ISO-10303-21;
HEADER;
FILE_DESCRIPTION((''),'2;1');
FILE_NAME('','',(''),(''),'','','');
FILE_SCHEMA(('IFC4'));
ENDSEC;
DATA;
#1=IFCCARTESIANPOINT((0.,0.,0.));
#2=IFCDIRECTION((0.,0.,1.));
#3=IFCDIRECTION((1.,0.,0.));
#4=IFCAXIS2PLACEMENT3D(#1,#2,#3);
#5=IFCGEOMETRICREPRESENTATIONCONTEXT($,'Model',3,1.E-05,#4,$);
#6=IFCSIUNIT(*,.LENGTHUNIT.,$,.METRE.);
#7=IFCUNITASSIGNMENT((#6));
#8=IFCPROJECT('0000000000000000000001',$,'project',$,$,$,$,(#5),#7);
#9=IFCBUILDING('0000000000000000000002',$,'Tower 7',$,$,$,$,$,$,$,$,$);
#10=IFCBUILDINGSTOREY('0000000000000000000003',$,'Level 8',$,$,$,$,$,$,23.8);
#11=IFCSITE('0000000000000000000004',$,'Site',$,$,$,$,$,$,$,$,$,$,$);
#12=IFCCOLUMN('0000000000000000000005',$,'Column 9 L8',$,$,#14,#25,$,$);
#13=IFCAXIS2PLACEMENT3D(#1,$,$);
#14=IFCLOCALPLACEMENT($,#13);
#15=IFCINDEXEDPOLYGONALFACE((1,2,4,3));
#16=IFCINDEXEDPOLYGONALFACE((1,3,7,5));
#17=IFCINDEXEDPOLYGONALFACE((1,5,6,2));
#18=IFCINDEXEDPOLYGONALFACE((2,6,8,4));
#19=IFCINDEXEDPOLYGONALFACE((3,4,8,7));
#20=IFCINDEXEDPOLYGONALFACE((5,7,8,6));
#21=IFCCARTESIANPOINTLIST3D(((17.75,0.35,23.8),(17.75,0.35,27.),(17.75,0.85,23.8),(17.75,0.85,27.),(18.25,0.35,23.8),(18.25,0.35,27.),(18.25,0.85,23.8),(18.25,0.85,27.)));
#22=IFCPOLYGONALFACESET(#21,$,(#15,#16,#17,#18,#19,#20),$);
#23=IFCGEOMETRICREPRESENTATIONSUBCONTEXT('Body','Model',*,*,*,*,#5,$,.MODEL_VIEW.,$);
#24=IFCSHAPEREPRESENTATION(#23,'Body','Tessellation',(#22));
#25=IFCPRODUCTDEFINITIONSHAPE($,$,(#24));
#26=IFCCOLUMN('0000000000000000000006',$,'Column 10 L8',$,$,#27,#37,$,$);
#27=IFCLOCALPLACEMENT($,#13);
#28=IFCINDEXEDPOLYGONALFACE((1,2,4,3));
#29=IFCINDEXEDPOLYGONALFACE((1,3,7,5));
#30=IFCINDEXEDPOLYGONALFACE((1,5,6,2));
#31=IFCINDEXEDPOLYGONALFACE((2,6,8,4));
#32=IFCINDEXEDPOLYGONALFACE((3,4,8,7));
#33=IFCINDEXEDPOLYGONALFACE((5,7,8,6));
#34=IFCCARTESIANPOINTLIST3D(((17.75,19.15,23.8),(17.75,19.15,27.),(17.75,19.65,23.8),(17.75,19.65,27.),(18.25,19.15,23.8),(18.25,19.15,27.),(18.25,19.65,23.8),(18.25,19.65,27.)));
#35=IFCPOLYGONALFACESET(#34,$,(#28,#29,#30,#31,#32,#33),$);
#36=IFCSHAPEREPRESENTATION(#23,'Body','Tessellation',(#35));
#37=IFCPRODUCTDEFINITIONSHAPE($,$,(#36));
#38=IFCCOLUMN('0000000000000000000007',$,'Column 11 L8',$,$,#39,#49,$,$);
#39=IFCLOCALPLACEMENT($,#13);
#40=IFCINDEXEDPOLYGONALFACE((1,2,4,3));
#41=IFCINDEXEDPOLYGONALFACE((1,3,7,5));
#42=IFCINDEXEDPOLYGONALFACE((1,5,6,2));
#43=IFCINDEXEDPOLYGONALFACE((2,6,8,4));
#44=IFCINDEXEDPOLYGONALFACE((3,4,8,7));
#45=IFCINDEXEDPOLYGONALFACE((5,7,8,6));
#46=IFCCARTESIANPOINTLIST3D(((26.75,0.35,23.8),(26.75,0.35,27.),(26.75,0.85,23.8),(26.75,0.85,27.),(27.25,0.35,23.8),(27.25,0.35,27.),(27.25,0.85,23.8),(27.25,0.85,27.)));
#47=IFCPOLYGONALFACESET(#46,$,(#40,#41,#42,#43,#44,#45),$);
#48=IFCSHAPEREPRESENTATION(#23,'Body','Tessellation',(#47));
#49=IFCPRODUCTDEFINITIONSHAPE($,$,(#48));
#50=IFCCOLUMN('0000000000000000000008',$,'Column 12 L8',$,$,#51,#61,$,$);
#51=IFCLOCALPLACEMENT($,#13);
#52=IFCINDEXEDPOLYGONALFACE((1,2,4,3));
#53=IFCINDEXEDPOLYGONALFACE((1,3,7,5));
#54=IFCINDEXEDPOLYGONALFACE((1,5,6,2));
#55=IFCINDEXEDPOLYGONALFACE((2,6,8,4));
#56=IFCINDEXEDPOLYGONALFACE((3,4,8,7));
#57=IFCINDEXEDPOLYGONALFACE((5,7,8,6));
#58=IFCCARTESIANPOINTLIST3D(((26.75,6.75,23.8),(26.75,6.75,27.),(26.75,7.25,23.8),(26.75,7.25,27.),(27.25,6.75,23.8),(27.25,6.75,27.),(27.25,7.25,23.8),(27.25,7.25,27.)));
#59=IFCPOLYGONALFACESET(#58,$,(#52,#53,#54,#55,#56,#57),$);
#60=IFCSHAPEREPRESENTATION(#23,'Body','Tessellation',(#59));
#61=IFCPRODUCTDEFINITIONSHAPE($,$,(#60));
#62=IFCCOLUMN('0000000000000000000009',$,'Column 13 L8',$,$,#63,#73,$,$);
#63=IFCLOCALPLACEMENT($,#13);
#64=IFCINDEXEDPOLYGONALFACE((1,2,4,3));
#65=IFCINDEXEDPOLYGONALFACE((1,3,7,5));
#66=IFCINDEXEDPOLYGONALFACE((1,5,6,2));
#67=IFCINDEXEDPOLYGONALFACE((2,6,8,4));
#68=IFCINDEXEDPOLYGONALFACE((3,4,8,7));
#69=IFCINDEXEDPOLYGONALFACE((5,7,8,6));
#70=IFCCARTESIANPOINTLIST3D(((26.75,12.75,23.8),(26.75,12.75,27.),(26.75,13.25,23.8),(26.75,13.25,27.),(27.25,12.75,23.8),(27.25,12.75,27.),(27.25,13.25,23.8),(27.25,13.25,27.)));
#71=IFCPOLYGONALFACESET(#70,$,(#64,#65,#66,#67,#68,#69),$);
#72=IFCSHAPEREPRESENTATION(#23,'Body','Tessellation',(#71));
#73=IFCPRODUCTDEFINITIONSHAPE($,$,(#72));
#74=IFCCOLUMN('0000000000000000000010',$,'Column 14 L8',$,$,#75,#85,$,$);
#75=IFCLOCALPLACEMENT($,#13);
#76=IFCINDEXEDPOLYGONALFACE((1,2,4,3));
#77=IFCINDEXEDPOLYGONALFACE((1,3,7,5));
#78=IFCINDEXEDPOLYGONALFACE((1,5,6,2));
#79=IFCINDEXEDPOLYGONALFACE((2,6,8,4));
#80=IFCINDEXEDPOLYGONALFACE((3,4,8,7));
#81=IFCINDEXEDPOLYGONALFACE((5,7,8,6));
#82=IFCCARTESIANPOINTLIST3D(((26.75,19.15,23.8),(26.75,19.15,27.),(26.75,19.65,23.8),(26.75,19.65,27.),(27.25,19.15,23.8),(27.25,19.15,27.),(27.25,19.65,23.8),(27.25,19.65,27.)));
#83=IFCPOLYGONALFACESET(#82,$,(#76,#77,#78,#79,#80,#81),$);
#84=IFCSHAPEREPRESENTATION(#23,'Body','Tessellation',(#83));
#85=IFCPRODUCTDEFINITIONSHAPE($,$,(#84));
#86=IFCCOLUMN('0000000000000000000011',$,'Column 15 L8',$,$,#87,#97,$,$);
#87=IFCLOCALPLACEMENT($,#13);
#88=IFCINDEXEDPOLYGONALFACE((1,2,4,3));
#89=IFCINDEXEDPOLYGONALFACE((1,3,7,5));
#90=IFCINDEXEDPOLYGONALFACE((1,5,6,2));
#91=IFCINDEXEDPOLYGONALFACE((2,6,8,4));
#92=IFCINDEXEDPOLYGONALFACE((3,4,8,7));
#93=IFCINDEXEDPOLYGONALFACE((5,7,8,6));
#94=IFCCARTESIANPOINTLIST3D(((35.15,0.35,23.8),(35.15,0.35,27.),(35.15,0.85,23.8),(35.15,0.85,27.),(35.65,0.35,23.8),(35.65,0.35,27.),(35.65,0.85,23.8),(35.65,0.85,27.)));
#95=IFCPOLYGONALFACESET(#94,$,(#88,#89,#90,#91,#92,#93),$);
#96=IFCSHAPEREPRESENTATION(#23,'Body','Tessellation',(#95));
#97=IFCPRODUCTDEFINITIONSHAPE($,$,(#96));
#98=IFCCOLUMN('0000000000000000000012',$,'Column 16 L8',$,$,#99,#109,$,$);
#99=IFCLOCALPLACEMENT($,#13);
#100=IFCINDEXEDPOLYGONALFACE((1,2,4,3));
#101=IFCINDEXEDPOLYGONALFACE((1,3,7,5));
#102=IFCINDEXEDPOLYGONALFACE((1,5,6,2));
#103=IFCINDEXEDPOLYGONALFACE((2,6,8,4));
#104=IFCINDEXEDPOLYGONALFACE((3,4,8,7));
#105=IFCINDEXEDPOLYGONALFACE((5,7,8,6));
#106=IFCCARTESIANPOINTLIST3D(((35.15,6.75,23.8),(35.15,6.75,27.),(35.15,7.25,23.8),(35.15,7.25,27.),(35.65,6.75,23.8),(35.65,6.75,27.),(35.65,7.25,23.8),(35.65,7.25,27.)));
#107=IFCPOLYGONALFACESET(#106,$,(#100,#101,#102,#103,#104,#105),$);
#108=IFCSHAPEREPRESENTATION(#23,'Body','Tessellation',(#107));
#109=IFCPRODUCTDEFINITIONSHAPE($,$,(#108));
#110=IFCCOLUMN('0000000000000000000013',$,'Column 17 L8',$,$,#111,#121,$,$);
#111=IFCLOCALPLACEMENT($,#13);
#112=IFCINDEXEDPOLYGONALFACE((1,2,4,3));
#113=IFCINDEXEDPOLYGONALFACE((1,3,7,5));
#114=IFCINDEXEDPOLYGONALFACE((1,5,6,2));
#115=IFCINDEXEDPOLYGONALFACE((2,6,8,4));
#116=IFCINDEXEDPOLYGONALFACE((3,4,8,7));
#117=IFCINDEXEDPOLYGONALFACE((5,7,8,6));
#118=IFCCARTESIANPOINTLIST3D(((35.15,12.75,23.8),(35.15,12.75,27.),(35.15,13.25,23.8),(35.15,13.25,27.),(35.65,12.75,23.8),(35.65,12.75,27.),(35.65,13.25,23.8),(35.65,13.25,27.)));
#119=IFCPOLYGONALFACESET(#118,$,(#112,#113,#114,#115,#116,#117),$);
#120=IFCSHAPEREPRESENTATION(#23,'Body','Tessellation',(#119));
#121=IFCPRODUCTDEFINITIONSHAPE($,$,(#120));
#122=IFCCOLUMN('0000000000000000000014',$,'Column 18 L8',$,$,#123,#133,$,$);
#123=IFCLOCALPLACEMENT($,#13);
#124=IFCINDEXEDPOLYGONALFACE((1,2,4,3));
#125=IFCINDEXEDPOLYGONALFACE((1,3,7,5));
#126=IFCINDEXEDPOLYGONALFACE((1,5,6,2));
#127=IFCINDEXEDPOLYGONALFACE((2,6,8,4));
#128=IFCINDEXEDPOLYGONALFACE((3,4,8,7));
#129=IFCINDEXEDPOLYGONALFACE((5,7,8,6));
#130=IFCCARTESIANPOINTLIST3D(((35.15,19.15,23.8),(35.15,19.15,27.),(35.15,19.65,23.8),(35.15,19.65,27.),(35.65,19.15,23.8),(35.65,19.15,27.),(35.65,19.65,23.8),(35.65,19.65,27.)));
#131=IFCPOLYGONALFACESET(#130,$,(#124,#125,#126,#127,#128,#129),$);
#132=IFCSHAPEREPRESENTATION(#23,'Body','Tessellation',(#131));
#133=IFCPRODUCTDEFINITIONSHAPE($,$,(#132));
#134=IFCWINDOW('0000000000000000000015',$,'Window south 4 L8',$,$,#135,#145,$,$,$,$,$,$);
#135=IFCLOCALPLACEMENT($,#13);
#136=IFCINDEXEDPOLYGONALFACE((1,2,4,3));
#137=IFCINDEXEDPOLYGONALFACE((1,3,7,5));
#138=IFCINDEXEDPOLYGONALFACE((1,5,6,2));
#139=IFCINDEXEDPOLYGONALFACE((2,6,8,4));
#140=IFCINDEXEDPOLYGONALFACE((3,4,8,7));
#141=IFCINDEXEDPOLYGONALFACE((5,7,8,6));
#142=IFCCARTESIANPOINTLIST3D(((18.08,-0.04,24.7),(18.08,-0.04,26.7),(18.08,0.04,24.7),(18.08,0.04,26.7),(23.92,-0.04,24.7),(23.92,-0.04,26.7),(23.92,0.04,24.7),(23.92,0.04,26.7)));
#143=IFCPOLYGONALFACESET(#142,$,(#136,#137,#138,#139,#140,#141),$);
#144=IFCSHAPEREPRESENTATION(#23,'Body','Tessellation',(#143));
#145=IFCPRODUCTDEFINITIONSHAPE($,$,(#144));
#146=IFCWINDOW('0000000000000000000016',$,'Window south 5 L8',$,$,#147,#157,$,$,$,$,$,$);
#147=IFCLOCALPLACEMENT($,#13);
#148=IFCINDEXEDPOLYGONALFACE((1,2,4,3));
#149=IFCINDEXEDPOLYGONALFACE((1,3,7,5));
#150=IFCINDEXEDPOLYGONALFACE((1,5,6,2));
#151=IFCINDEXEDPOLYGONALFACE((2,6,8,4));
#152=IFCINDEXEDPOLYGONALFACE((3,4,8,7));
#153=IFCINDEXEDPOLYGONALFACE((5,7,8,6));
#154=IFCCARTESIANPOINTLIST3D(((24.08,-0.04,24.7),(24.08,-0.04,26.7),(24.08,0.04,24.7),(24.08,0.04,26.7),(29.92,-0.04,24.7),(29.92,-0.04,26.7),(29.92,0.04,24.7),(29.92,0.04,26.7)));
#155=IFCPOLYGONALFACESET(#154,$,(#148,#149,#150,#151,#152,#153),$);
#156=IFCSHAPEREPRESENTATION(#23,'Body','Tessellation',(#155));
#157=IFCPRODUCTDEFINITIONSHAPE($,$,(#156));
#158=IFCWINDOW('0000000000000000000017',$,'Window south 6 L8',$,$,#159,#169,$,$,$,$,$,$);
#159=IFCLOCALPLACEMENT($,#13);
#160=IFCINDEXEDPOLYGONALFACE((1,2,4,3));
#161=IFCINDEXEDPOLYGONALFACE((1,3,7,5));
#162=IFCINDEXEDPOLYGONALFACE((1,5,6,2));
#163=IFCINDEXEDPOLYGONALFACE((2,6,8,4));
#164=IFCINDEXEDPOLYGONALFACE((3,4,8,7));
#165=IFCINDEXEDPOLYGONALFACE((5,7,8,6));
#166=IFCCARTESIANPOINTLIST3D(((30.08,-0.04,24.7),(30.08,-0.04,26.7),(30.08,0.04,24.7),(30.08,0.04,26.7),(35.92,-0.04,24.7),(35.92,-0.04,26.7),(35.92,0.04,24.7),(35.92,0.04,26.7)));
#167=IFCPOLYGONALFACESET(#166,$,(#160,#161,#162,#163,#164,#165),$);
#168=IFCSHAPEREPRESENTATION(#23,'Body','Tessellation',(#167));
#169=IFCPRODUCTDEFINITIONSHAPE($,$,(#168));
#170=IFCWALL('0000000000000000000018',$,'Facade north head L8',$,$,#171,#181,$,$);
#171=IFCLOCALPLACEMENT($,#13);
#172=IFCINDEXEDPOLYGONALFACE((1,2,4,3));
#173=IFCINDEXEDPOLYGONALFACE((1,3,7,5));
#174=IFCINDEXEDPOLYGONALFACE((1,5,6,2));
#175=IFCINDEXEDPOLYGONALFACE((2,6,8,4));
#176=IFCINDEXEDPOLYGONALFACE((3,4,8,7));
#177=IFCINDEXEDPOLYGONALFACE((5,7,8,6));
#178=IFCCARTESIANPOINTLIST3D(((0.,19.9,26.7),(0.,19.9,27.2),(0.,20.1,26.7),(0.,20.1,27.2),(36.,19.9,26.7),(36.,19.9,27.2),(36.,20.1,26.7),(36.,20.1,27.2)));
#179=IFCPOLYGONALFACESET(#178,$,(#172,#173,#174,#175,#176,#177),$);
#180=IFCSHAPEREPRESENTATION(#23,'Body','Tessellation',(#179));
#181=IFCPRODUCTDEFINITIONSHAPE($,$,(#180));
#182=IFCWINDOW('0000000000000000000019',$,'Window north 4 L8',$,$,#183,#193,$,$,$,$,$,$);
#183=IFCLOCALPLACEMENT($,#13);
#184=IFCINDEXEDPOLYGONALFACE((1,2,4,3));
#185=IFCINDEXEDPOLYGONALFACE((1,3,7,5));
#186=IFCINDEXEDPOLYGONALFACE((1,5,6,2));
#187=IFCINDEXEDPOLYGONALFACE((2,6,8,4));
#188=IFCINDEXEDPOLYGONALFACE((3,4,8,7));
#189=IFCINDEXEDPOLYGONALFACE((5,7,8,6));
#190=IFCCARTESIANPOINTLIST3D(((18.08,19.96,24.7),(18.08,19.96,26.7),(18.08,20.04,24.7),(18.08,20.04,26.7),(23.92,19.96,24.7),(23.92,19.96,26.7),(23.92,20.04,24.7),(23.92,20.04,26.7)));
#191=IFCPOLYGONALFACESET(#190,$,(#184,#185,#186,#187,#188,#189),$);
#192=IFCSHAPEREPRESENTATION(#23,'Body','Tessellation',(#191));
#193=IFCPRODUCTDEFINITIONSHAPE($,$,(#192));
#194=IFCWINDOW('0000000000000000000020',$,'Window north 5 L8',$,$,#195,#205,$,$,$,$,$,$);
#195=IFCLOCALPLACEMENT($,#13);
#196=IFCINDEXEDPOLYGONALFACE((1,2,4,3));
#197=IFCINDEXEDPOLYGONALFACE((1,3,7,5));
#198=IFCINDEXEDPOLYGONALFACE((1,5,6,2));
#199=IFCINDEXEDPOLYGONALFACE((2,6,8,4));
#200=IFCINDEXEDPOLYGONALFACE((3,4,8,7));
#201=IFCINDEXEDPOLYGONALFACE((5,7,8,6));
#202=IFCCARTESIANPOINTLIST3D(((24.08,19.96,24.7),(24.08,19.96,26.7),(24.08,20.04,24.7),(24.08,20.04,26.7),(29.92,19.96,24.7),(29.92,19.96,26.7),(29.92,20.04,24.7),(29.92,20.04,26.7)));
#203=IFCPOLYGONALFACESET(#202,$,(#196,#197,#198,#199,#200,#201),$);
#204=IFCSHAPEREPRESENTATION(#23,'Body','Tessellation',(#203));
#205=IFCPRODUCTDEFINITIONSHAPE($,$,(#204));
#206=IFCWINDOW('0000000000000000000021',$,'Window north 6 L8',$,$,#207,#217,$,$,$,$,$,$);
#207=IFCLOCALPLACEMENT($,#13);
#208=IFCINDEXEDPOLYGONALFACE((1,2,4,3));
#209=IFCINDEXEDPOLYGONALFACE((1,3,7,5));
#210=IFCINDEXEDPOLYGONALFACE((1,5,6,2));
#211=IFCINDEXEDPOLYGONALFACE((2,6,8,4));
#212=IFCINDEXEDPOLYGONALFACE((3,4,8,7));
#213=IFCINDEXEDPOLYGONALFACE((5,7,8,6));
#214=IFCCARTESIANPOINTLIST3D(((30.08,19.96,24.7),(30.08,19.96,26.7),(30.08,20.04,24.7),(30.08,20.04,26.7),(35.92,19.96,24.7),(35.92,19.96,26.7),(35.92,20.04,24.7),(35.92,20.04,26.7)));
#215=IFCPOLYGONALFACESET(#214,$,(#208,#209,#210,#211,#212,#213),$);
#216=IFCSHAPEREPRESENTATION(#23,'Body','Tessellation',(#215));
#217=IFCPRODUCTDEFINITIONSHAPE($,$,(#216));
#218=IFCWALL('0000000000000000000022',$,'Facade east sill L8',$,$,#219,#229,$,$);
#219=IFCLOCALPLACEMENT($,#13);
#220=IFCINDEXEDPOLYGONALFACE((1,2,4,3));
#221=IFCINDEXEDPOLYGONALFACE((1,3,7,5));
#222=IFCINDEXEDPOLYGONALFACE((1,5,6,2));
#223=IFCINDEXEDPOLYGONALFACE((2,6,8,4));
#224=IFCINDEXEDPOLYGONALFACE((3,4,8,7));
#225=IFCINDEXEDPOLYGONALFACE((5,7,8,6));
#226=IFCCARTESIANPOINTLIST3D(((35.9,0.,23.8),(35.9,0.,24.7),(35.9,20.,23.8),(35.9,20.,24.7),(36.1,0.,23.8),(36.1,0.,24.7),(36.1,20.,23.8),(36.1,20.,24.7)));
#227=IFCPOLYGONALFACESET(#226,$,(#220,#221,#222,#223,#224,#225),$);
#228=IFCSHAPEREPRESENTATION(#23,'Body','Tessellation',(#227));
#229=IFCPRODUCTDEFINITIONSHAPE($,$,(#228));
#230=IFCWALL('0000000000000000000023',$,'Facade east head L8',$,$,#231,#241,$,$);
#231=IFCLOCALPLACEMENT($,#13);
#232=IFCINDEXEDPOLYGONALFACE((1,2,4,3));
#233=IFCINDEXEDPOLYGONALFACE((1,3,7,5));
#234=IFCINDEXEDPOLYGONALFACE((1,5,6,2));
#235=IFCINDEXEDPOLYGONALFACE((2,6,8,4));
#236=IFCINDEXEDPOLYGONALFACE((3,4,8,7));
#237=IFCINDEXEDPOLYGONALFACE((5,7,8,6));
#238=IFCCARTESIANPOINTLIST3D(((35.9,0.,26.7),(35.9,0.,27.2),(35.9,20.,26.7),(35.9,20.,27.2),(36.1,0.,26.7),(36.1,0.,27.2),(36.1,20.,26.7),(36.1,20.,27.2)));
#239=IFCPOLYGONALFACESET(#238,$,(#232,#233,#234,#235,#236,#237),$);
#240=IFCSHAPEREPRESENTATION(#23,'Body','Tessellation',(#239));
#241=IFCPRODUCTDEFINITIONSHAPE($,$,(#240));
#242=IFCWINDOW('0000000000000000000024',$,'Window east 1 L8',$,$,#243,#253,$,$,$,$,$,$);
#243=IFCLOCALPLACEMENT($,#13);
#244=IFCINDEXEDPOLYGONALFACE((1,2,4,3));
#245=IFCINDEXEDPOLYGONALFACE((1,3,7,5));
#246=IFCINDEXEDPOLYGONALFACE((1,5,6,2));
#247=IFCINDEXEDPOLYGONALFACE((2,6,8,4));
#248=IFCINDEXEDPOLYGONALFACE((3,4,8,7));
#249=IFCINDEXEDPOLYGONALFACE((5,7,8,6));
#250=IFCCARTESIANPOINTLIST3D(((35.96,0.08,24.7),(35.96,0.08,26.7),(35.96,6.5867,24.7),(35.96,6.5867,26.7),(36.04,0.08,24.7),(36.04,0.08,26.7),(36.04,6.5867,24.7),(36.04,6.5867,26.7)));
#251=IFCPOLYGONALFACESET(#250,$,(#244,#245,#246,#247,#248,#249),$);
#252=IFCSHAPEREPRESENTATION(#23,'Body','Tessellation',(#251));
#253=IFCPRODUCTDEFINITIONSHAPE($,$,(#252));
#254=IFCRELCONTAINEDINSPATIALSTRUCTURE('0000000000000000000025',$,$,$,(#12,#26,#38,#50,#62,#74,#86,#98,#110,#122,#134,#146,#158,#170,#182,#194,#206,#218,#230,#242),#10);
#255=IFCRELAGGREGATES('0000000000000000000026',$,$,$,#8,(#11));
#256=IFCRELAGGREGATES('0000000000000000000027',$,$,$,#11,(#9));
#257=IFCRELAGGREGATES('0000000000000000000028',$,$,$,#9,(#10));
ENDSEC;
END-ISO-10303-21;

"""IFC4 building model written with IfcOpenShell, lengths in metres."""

from ifc_helpers import new_model, si_unit, frame, origin, origin_with_axes, origin_2d, place, context, subcontext, project, spatial, rectangle, extrude, element, save


model = new_model("IFC4")

# Units and contexts
model_context = context("Model", 3, precision=1e-05, world=origin_with_axes())
body_context = subcontext(model_context, "Body", "Model", "MODEL_VIEW")
ifc_project = project(units=[si_unit("LENGTHUNIT", "METRE")], contexts=[model_context])

# Site, building, storey
site = spatial("IfcSite", under=ifc_project, Name="Site")
building = spatial("IfcBuilding", under=site, Name="Tower 7")
storey = spatial("IfcBuildingStorey", under=building, Name="Level 8", Elevation=23.8)

# Columns
for number, where, z_axis, x_axis, name in (
    (1, (18.0, 0.6, 23.8), (0.0, 0.0, 1.0), (1.0, 0.0, 0.0), "Column 9 L8"),
    (2, (18.0, 19.4, 23.8), (0.0, 0.0, 1.0), (1.0, 0.0, 0.0), "Column 10 L8"),
    (3, (27.0, 0.6, 23.8), (0.0, 0.0, 1.0), (1.0, 0.0, 0.0), "Column 11 L8"),
    (4, (27.0, 7.0, 23.8), (0.0, 0.0, 1.0), (1.0, 0.0, 0.0), "Column 12 L8"),
    (5, (27.0, 13.0, 23.8), (0.0, 0.0, 1.0), (1.0, 0.0, 0.0), "Column 13 L8"),
    (6, (27.0, 19.4, 23.8), (0.0, 0.0, 1.0), (1.0, 0.0, 0.0), "Column 14 L8"),
    (7, (35.4, 0.6, 23.8), (0.0, 0.0, 1.0), (1.0, 0.0, 0.0), "Column 15 L8"),
    (8, (35.4, 7.0, 23.8), (0.0, 0.0, 1.0), (1.0, 0.0, 0.0), "Column 16 L8"),
    (9, (35.4, 13.0, 23.8), (0.0, 0.0, 1.0), (1.0, 0.0, 0.0), "Column 17 L8"),
    (10, (35.4, 19.4, 23.8), (0.0, 0.0, 1.0), (1.0, 0.0, 0.0), "Column 18 L8"),
):
    element("IfcColumn", number, at=place(None, frame(where, z_axis=z_axis, x_axis=x_axis)), inside=storey, Name=name, context=body_context, shape_type="SweptSolid", body=[
        extrude(rectangle(XDim=0.5, YDim=0.5, at=origin_2d()), origin(), (0.0, 0.0, 1.0), 3.2),
    ])

# Windows
for number, where, z_axis, x_axis, name in (
    (11, (21.0, 0.0, 24.7), (0.0, 0.0, 1.0), (1.0, 0.0, 0.0), "Window south 4 L8"),
    (12, (27.0, 0.0, 24.7), (0.0, 0.0, 1.0), (1.0, 0.0, 0.0), "Window south 5 L8"),
    (13, (33.0, 0.0, 24.7), (0.0, 0.0, 1.0), (1.0, 0.0, 0.0), "Window south 6 L8"),
):
    element("IfcWindow", number, at=place(None, frame(where, z_axis=z_axis, x_axis=x_axis)), inside=storey, Name=name, context=body_context, shape_type="SweptSolid", body=[
        extrude(rectangle(XDim=5.84, YDim=0.08, at=origin_2d()), origin(), (0.0, 0.0, 1.0), 2.0),
    ])

# Wall
wall_1_placement = place(None, frame((18.0, 20.0, 26.7), z_axis=(0.0, 0.0, 1.0), x_axis=(1.0, 0.0, 0.0)))
element("IfcWall", 14, at=wall_1_placement, inside=storey, Name="Facade north head L8", context=body_context, shape_type="SweptSolid", body=[
    extrude(rectangle(XDim=36.0, YDim=0.2, at=origin_2d()), origin(), (0.0, 0.0, 1.0), 0.5),
])

# Windows
for number, where, z_axis, x_axis, name in (
    (15, (21.0, 20.0, 24.7), (0.0, 0.0, 1.0), (1.0, 0.0, 0.0), "Window north 4 L8"),
    (16, (27.0, 20.0, 24.7), (0.0, 0.0, 1.0), (1.0, 0.0, 0.0), "Window north 5 L8"),
    (17, (33.0, 20.0, 24.7), (0.0, 0.0, 1.0), (1.0, 0.0, 0.0), "Window north 6 L8"),
):
    element("IfcWindow", number, at=place(None, frame(where, z_axis=z_axis, x_axis=x_axis)), inside=storey, Name=name, context=body_context, shape_type="SweptSolid", body=[
        extrude(rectangle(XDim=5.84, YDim=0.08, at=origin_2d()), origin(), (0.0, 0.0, 1.0), 2.0),
    ])

# Walls
wall_2_placement = place(None, frame((36.0, 10.0, 23.8), z_axis=(0.0, 0.0, 1.0), x_axis=(1.0, 0.0, 0.0)))
element("IfcWall", 18, at=wall_2_placement, inside=storey, Name="Facade east sill L8", context=body_context, shape_type="SweptSolid", body=[
    extrude(rectangle(XDim=0.2, YDim=20.0, at=origin_2d()), origin(), (0.0, 0.0, 1.0), 0.9),
])
wall_3_placement = place(None, frame((36.0, 10.0, 26.7), z_axis=(0.0, 0.0, 1.0), x_axis=(1.0, 0.0, 0.0)))
element("IfcWall", 19, at=wall_3_placement, inside=storey, Name="Facade east head L8", context=body_context, shape_type="SweptSolid", body=[
    extrude(rectangle(XDim=0.2, YDim=20.0, at=origin_2d()), origin(), (0.0, 0.0, 1.0), 0.5),
])

# Window
for number, where, z_axis, x_axis, name in (
    (20, (36.0, 3.3333, 24.7), (0.0, 0.0, 1.0), (1.0, 0.0, 0.0), "Window east 1 L8"),
):
    element("IfcWindow", number, at=place(None, frame(where, z_axis=z_axis, x_axis=x_axis)), inside=storey, Name=name, context=body_context, shape_type="SweptSolid", body=[
        extrude(rectangle(XDim=0.08, YDim=6.5067, at=origin_2d()), origin(), (0.0, 0.0, 1.0), 2.0),
    ])

save(model, "model.ifc")
